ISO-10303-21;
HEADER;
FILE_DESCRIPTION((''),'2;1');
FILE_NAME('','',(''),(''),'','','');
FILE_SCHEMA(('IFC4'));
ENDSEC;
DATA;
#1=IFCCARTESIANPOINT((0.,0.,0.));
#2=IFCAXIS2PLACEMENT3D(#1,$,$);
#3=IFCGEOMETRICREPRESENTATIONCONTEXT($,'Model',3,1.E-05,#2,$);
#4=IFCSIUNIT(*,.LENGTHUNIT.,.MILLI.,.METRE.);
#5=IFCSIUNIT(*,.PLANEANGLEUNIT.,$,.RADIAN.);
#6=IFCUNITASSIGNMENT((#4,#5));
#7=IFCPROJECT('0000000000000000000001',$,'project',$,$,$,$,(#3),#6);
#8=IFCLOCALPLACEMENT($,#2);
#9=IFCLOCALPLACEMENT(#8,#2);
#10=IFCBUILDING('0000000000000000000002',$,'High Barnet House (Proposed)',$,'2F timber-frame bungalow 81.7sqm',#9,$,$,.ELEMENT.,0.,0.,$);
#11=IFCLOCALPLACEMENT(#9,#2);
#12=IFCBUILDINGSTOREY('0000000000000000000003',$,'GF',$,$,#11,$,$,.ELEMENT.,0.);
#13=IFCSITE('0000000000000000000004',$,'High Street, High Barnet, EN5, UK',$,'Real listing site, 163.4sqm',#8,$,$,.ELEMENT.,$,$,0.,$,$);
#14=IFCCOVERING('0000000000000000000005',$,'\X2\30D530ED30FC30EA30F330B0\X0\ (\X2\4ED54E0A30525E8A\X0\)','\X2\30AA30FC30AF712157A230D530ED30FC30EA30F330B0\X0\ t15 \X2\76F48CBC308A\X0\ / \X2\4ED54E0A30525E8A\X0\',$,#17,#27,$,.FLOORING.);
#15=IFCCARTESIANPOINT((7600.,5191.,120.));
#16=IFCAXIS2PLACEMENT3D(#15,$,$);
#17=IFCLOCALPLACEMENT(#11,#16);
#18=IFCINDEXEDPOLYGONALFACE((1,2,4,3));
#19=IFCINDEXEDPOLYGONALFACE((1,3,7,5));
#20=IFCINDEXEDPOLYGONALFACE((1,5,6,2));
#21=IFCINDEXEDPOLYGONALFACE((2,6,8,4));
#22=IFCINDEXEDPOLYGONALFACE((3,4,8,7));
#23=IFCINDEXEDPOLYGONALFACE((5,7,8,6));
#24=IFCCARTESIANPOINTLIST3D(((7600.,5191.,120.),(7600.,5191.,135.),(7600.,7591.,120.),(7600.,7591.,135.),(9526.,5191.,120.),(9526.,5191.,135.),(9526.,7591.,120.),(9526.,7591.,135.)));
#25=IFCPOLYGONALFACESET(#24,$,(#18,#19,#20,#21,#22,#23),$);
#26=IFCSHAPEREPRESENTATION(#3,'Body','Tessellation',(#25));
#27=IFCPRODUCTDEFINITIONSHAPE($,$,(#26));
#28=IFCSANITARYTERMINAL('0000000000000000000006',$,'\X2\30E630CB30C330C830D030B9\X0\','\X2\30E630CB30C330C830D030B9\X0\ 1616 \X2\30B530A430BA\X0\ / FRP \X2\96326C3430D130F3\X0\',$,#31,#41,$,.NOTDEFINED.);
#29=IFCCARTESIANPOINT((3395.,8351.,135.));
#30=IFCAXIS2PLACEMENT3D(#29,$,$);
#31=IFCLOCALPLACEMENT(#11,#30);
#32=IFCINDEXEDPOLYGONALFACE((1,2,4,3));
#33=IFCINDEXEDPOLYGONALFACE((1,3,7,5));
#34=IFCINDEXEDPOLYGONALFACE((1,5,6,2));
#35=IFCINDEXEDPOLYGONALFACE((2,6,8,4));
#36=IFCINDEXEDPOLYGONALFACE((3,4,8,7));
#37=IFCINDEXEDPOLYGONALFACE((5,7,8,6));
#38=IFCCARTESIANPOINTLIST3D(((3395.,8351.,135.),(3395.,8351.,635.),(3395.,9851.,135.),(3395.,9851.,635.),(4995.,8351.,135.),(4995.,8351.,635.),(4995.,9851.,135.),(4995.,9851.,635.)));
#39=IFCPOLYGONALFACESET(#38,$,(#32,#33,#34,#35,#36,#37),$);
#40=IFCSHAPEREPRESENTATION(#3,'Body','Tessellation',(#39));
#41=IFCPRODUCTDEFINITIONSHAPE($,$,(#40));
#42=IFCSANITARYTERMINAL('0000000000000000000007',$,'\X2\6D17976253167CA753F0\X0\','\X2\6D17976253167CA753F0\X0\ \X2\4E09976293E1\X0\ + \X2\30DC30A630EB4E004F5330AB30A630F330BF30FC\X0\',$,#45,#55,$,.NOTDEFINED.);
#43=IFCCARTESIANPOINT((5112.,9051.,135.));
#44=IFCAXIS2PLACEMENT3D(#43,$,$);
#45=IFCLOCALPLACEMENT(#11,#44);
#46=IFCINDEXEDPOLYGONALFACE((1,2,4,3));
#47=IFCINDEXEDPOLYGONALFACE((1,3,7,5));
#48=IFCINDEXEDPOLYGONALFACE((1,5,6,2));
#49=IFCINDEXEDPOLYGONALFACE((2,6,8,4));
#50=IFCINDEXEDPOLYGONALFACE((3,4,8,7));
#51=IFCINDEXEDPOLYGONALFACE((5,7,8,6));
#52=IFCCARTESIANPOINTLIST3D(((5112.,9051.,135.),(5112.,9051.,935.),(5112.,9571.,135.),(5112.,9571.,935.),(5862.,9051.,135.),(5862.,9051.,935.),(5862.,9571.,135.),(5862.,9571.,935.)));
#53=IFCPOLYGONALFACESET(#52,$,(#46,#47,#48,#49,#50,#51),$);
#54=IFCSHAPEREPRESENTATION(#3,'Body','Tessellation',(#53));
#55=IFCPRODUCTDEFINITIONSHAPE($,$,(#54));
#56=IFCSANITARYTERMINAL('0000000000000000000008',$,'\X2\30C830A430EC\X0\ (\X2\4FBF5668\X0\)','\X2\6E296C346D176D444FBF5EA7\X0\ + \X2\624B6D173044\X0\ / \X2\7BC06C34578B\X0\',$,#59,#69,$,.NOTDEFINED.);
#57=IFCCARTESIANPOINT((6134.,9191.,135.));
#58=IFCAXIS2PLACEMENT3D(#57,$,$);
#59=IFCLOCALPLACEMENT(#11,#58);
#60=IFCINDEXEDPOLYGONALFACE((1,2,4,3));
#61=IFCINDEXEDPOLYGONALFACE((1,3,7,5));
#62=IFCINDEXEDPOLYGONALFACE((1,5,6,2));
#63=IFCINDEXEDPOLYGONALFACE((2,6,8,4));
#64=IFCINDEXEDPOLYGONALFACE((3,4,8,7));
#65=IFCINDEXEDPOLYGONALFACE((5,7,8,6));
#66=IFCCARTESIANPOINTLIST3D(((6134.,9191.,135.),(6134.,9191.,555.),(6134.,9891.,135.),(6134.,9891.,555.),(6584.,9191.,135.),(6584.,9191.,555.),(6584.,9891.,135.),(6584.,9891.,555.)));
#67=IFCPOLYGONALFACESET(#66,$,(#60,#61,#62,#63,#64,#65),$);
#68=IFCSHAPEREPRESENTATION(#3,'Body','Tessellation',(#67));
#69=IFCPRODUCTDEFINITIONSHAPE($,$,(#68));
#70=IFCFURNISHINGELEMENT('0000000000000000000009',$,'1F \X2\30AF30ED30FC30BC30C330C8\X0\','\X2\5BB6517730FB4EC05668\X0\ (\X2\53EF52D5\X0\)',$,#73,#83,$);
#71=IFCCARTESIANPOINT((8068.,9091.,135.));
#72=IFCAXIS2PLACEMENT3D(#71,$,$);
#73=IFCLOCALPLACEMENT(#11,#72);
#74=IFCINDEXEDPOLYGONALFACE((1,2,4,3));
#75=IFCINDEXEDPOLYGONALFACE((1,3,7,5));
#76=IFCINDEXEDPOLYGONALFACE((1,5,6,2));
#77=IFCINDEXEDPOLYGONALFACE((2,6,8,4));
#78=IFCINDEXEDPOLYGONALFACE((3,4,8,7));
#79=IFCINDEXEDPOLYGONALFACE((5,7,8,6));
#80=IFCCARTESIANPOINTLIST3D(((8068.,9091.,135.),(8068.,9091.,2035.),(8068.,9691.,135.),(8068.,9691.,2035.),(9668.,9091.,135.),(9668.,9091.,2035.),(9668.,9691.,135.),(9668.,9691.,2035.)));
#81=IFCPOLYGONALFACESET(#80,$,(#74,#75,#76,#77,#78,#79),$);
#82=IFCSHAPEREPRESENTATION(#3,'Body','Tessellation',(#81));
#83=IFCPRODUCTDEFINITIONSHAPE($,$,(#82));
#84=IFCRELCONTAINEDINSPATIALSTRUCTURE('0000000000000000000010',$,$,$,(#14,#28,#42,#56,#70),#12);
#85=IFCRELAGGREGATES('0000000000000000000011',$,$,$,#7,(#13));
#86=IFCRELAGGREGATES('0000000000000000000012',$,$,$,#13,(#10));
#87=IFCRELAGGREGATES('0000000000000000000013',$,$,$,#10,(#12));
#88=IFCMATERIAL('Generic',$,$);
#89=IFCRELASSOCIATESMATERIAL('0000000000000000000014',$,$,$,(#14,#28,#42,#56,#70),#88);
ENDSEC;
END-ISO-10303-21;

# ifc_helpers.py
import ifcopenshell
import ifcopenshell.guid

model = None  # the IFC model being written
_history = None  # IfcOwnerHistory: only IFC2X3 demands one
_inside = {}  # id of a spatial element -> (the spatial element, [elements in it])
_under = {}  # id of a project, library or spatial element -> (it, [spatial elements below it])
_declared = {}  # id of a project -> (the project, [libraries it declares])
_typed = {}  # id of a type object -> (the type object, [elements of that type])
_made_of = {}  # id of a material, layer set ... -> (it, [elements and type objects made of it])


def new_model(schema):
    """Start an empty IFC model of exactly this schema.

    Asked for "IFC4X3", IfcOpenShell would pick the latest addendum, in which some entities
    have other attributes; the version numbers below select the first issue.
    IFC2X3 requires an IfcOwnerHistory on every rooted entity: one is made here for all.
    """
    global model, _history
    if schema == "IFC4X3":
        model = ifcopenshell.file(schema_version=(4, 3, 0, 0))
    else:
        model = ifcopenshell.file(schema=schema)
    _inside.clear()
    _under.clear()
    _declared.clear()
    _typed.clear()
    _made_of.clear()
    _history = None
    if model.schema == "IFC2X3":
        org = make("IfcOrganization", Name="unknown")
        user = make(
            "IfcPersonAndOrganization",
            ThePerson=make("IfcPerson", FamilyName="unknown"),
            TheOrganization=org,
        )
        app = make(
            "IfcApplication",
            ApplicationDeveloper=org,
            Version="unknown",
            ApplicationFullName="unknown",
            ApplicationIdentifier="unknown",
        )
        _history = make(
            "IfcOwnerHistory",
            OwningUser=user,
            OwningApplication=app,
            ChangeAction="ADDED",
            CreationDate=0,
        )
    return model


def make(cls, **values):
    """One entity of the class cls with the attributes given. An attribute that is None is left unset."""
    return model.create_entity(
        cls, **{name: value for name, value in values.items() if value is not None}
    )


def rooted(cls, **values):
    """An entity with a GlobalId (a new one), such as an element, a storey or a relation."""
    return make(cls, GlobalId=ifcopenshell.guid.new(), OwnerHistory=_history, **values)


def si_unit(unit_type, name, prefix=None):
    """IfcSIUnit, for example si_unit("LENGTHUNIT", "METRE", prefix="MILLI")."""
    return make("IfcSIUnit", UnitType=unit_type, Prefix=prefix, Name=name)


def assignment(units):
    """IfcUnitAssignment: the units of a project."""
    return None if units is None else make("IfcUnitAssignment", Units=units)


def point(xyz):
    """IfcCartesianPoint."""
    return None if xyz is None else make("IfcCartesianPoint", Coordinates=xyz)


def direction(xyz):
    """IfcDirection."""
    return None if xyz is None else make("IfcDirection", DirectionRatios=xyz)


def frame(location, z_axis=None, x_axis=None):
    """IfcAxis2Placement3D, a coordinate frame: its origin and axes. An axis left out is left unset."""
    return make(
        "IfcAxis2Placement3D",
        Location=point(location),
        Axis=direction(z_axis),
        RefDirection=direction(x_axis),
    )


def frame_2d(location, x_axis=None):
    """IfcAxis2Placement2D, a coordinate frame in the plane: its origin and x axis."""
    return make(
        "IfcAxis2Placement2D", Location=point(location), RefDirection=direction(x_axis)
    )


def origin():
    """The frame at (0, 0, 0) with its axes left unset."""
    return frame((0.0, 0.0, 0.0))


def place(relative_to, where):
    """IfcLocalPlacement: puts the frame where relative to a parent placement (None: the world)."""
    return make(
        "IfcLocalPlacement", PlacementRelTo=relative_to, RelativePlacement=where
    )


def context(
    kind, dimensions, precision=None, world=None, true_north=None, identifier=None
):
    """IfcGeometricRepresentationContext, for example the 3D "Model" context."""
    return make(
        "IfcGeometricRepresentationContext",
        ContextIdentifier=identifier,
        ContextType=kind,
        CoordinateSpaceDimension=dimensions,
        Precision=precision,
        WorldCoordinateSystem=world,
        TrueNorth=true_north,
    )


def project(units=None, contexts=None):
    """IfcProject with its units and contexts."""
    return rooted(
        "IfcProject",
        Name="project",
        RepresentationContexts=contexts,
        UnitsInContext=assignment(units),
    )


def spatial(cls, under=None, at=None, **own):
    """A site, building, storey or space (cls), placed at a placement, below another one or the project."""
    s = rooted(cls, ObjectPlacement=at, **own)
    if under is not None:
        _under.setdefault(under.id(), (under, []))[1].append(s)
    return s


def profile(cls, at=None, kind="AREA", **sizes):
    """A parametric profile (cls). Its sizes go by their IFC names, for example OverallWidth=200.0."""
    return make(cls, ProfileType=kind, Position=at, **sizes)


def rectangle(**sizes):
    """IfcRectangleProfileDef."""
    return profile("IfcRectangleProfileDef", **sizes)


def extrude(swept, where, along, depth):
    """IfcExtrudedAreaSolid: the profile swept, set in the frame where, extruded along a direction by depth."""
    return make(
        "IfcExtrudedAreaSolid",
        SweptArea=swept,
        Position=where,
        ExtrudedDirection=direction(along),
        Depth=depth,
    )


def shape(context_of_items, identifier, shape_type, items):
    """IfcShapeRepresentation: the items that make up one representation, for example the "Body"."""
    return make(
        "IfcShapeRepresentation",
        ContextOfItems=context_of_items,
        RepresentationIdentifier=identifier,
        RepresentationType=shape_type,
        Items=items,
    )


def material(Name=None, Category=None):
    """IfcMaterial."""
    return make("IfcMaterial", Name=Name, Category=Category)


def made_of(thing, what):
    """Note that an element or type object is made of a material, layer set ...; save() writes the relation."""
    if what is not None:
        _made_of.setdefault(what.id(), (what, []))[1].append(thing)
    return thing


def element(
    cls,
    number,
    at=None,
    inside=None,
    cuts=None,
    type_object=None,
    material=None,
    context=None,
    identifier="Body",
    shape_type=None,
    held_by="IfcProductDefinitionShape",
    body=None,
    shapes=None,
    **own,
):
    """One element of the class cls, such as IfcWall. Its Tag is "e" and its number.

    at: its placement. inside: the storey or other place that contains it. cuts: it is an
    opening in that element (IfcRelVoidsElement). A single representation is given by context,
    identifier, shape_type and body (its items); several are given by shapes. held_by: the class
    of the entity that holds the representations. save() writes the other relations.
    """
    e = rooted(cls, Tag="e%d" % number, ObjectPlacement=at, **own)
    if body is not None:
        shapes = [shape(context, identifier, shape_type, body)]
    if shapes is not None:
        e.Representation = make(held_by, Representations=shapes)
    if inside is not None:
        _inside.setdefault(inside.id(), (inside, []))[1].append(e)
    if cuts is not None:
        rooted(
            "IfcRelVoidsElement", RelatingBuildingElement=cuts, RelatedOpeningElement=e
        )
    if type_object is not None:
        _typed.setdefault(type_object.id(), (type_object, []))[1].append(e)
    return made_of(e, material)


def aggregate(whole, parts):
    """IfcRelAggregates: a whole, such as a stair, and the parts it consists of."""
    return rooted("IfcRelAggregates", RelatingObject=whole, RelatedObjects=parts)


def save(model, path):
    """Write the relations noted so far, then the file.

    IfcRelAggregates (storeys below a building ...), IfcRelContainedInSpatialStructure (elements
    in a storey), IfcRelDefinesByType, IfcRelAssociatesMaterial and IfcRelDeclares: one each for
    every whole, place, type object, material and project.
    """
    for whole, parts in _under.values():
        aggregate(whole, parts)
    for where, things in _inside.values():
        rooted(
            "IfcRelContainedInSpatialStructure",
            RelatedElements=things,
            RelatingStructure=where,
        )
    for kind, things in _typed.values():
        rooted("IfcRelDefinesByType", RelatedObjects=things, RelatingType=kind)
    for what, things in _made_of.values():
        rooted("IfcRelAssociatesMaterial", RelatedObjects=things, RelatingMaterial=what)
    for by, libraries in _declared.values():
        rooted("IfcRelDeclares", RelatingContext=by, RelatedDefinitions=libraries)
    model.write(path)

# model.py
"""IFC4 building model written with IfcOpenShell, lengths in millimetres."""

from ifc_helpers import new_model, si_unit, frame, frame_2d, origin, place, context, project, spatial, rectangle, extrude, material, element, save


model = new_model("IFC4")

# Units and contexts
model_context = context("Model", 3, precision=1e-05, world=origin())
ifc_project = project(units=[si_unit("LENGTHUNIT", "METRE", prefix="MILLI"), si_unit("PLANEANGLEUNIT", "RADIAN")], contexts=[model_context])

# Site, building, storey
site_placement = place(None, origin())
site = spatial("IfcSite", under=ifc_project, at=site_placement, Name="High Street, High Barnet, EN5, UK", ObjectType="Real listing site, 163.4sqm", CompositionType="ELEMENT", RefElevation=0.0)
building_placement = place(site_placement, origin())
building = spatial("IfcBuilding", under=site, at=building_placement, Name="High Barnet House (Proposed)", ObjectType="2F timber-frame bungalow 81.7sqm", CompositionType="ELEMENT", ElevationOfRefHeight=0.0, ElevationOfTerrain=0.0)
storey_placement = place(building_placement, origin())
storey = spatial("IfcBuildingStorey", under=building, at=storey_placement, Name="GF", CompositionType="ELEMENT", Elevation=0.0)

# Covering
ifc_material_1 = material(Name="Generic")
covering_1_placement = place(storey_placement, frame((7600.0, 5191.0, 120.0)))
element("IfcCovering", 1, at=covering_1_placement, inside=storey, material=ifc_material_1, Name="フローリング (仕上げ床)", Description="オーク無垢フローリング t15 直貼り / 仕上げ床", PredefinedType="FLOORING", context=model_context, shape_type="SweptSolid", body=[
    extrude(rectangle(XDim=1926.0, YDim=2400.0, at=frame_2d((963.0, 1200.0))), frame((7600.0, 5191.0, 120.0)), (0.0, 0.0, 1.0), 15.0),
])

# Sanitary terminals
sanitary_terminal_1_placement = place(storey_placement, frame((3395.0, 8351.0, 135.0)))
element("IfcSanitaryTerminal", 2, at=sanitary_terminal_1_placement, inside=storey, material=ifc_material_1, Name="ユニットバス", Description="ユニットバス 1616 サイズ / FRP 防水パン", PredefinedType="NOTDEFINED", context=model_context, shape_type="SweptSolid", body=[
    extrude(rectangle(XDim=1600.0, YDim=1500.0, at=frame_2d((800.0, 750.0))), frame((3395.0, 8351.0, 135.0)), (0.0, 0.0, 1.0), 500.0),
])
sanitary_terminal_2_placement = place(storey_placement, frame((5112.0, 9051.0, 135.0)))
element("IfcSanitaryTerminal", 3, at=sanitary_terminal_2_placement, inside=storey, material=ifc_material_1, Name="洗面化粧台", Description="洗面化粧台 三面鏡 + ボウル一体カウンター", PredefinedType="NOTDEFINED", context=model_context, shape_type="SweptSolid", body=[
    extrude(rectangle(XDim=750.0, YDim=520.0, at=frame_2d((375.0, 260.0))), frame((5112.0, 9051.0, 135.0)), (0.0, 0.0, 1.0), 800.0),
])
sanitary_terminal_3_placement = place(storey_placement, frame((6134.0, 9191.0, 135.0)))
element("IfcSanitaryTerminal", 4, at=sanitary_terminal_3_placement, inside=storey, material=ifc_material_1, Name="トイレ (便器)", Description="温水洗浄便座 + 手洗い / 節水型", PredefinedType="NOTDEFINED", context=model_context, shape_type="SweptSolid", body=[
    extrude(rectangle(XDim=450.0, YDim=700.0, at=frame_2d((225.0, 350.0))), frame((6134.0, 9191.0, 135.0)), (0.0, 0.0, 1.0), 420.0),
])

# Furnishing element
furnishing_placement = place(storey_placement, frame((8068.0, 9091.0, 135.0)))
element("IfcFurnishingElement", 5, at=furnishing_placement, inside=storey, material=ifc_material_1, Name="1F クローゼット", Description="家具・什器 (可動)", context=model_context, shape_type="SweptSolid", body=[
    extrude(rectangle(XDim=1600.0, YDim=600.0, at=frame_2d((800.0, 300.0))), frame((8068.0, 9091.0, 135.0)), (0.0, 0.0, 1.0), 1900.0),
])

save(model, "model.ifc")
